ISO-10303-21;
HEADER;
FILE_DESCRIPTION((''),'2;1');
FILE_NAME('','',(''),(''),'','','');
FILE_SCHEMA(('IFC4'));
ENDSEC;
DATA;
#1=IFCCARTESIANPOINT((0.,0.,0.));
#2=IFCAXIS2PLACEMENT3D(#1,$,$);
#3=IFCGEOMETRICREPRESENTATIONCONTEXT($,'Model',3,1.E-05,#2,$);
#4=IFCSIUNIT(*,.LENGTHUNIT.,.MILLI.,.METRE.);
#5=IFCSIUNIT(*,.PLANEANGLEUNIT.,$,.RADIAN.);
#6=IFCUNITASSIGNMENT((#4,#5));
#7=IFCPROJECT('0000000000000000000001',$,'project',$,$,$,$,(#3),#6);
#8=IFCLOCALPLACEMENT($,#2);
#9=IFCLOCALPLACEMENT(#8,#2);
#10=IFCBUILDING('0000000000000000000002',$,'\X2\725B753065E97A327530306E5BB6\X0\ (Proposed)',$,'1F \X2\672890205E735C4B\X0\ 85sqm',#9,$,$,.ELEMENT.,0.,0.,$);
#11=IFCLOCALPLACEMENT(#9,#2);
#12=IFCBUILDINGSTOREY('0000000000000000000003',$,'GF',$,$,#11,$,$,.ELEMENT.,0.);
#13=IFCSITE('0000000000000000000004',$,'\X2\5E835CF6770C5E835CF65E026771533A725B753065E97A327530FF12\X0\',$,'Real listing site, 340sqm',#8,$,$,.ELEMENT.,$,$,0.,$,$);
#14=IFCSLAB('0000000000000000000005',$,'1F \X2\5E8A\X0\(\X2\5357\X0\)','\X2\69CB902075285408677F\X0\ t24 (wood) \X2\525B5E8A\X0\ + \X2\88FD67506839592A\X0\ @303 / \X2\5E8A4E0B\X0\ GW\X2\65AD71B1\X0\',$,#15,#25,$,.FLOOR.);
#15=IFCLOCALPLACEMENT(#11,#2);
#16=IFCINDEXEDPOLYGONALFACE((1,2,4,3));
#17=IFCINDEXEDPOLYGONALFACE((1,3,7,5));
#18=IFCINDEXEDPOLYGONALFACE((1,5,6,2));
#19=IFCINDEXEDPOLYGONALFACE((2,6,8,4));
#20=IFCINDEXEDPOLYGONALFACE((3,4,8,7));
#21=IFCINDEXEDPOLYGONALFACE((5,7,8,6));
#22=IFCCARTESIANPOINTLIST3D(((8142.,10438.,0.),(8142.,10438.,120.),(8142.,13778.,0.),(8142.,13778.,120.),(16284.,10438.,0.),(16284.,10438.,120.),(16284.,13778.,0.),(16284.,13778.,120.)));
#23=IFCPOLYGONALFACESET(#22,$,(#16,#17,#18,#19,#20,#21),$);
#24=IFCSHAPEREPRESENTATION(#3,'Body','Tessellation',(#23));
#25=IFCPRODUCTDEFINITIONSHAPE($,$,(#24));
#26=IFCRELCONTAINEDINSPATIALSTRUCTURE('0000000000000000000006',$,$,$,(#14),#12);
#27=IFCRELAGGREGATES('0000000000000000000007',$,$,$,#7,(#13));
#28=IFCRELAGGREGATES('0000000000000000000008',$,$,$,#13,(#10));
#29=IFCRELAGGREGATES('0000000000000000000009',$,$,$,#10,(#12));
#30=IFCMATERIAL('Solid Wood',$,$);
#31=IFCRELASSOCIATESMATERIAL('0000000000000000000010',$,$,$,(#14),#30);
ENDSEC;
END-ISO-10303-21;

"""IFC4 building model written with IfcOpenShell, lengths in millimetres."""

from ifc_helpers import new_model, si_unit, frame, frame_2d, origin, place, context, project, spatial, rectangle, extrude, material, element, save


model = new_model("IFC4")

# Units and contexts
model_context = context("Model", 3, precision=1e-05, world=origin())
ifc_project = project(units=[si_unit("LENGTHUNIT", "METRE", prefix="MILLI"), si_unit("PLANEANGLEUNIT", "RADIAN")], contexts=[model_context])

# Site, building, storey
site_placement = place(None, origin())
site = spatial("IfcSite", under=ifc_project, at=site_placement, Name="広島県広島市東区牛田早稲田２", ObjectType="Real listing site, 340sqm", CompositionType="ELEMENT", RefElevation=0.0)
building_placement = place(site_placement, origin())
building = spatial("IfcBuilding", under=site, at=building_placement, Name="牛田早稲田の家 (Proposed)", ObjectType="1F 木造平屋 85sqm", CompositionType="ELEMENT", ElevationOfRefHeight=0.0, ElevationOfTerrain=0.0)
storey_placement = place(building_placement, origin())
storey = spatial("IfcBuildingStorey", under=building, at=storey_placement, Name="GF", CompositionType="ELEMENT", Elevation=0.0)

# Slab
ifc_material_1 = material(Name="Solid Wood")
slab_1_placement = place(storey_placement, frame((4071.0, 5219.0, 0.0)))
element("IfcSlab", 1, at=slab_1_placement, inside=storey, material=ifc_material_1, Name="1F 床(南)", Description="構造用合板 t24 (wood) 剛床 + 製材根太 @303 / 床下 GW断熱", PredefinedType="FLOOR", context=model_context, shape_type="SweptSolid", body=[
    extrude(rectangle(XDim=8142.0, YDim=3340.0, at=frame_2d((4071.0, 1670.0))), frame((4071.0, 5219.0, 0.0)), (0.0, 0.0, 1.0), 120.0),
])

save(model, "model.ifc")
